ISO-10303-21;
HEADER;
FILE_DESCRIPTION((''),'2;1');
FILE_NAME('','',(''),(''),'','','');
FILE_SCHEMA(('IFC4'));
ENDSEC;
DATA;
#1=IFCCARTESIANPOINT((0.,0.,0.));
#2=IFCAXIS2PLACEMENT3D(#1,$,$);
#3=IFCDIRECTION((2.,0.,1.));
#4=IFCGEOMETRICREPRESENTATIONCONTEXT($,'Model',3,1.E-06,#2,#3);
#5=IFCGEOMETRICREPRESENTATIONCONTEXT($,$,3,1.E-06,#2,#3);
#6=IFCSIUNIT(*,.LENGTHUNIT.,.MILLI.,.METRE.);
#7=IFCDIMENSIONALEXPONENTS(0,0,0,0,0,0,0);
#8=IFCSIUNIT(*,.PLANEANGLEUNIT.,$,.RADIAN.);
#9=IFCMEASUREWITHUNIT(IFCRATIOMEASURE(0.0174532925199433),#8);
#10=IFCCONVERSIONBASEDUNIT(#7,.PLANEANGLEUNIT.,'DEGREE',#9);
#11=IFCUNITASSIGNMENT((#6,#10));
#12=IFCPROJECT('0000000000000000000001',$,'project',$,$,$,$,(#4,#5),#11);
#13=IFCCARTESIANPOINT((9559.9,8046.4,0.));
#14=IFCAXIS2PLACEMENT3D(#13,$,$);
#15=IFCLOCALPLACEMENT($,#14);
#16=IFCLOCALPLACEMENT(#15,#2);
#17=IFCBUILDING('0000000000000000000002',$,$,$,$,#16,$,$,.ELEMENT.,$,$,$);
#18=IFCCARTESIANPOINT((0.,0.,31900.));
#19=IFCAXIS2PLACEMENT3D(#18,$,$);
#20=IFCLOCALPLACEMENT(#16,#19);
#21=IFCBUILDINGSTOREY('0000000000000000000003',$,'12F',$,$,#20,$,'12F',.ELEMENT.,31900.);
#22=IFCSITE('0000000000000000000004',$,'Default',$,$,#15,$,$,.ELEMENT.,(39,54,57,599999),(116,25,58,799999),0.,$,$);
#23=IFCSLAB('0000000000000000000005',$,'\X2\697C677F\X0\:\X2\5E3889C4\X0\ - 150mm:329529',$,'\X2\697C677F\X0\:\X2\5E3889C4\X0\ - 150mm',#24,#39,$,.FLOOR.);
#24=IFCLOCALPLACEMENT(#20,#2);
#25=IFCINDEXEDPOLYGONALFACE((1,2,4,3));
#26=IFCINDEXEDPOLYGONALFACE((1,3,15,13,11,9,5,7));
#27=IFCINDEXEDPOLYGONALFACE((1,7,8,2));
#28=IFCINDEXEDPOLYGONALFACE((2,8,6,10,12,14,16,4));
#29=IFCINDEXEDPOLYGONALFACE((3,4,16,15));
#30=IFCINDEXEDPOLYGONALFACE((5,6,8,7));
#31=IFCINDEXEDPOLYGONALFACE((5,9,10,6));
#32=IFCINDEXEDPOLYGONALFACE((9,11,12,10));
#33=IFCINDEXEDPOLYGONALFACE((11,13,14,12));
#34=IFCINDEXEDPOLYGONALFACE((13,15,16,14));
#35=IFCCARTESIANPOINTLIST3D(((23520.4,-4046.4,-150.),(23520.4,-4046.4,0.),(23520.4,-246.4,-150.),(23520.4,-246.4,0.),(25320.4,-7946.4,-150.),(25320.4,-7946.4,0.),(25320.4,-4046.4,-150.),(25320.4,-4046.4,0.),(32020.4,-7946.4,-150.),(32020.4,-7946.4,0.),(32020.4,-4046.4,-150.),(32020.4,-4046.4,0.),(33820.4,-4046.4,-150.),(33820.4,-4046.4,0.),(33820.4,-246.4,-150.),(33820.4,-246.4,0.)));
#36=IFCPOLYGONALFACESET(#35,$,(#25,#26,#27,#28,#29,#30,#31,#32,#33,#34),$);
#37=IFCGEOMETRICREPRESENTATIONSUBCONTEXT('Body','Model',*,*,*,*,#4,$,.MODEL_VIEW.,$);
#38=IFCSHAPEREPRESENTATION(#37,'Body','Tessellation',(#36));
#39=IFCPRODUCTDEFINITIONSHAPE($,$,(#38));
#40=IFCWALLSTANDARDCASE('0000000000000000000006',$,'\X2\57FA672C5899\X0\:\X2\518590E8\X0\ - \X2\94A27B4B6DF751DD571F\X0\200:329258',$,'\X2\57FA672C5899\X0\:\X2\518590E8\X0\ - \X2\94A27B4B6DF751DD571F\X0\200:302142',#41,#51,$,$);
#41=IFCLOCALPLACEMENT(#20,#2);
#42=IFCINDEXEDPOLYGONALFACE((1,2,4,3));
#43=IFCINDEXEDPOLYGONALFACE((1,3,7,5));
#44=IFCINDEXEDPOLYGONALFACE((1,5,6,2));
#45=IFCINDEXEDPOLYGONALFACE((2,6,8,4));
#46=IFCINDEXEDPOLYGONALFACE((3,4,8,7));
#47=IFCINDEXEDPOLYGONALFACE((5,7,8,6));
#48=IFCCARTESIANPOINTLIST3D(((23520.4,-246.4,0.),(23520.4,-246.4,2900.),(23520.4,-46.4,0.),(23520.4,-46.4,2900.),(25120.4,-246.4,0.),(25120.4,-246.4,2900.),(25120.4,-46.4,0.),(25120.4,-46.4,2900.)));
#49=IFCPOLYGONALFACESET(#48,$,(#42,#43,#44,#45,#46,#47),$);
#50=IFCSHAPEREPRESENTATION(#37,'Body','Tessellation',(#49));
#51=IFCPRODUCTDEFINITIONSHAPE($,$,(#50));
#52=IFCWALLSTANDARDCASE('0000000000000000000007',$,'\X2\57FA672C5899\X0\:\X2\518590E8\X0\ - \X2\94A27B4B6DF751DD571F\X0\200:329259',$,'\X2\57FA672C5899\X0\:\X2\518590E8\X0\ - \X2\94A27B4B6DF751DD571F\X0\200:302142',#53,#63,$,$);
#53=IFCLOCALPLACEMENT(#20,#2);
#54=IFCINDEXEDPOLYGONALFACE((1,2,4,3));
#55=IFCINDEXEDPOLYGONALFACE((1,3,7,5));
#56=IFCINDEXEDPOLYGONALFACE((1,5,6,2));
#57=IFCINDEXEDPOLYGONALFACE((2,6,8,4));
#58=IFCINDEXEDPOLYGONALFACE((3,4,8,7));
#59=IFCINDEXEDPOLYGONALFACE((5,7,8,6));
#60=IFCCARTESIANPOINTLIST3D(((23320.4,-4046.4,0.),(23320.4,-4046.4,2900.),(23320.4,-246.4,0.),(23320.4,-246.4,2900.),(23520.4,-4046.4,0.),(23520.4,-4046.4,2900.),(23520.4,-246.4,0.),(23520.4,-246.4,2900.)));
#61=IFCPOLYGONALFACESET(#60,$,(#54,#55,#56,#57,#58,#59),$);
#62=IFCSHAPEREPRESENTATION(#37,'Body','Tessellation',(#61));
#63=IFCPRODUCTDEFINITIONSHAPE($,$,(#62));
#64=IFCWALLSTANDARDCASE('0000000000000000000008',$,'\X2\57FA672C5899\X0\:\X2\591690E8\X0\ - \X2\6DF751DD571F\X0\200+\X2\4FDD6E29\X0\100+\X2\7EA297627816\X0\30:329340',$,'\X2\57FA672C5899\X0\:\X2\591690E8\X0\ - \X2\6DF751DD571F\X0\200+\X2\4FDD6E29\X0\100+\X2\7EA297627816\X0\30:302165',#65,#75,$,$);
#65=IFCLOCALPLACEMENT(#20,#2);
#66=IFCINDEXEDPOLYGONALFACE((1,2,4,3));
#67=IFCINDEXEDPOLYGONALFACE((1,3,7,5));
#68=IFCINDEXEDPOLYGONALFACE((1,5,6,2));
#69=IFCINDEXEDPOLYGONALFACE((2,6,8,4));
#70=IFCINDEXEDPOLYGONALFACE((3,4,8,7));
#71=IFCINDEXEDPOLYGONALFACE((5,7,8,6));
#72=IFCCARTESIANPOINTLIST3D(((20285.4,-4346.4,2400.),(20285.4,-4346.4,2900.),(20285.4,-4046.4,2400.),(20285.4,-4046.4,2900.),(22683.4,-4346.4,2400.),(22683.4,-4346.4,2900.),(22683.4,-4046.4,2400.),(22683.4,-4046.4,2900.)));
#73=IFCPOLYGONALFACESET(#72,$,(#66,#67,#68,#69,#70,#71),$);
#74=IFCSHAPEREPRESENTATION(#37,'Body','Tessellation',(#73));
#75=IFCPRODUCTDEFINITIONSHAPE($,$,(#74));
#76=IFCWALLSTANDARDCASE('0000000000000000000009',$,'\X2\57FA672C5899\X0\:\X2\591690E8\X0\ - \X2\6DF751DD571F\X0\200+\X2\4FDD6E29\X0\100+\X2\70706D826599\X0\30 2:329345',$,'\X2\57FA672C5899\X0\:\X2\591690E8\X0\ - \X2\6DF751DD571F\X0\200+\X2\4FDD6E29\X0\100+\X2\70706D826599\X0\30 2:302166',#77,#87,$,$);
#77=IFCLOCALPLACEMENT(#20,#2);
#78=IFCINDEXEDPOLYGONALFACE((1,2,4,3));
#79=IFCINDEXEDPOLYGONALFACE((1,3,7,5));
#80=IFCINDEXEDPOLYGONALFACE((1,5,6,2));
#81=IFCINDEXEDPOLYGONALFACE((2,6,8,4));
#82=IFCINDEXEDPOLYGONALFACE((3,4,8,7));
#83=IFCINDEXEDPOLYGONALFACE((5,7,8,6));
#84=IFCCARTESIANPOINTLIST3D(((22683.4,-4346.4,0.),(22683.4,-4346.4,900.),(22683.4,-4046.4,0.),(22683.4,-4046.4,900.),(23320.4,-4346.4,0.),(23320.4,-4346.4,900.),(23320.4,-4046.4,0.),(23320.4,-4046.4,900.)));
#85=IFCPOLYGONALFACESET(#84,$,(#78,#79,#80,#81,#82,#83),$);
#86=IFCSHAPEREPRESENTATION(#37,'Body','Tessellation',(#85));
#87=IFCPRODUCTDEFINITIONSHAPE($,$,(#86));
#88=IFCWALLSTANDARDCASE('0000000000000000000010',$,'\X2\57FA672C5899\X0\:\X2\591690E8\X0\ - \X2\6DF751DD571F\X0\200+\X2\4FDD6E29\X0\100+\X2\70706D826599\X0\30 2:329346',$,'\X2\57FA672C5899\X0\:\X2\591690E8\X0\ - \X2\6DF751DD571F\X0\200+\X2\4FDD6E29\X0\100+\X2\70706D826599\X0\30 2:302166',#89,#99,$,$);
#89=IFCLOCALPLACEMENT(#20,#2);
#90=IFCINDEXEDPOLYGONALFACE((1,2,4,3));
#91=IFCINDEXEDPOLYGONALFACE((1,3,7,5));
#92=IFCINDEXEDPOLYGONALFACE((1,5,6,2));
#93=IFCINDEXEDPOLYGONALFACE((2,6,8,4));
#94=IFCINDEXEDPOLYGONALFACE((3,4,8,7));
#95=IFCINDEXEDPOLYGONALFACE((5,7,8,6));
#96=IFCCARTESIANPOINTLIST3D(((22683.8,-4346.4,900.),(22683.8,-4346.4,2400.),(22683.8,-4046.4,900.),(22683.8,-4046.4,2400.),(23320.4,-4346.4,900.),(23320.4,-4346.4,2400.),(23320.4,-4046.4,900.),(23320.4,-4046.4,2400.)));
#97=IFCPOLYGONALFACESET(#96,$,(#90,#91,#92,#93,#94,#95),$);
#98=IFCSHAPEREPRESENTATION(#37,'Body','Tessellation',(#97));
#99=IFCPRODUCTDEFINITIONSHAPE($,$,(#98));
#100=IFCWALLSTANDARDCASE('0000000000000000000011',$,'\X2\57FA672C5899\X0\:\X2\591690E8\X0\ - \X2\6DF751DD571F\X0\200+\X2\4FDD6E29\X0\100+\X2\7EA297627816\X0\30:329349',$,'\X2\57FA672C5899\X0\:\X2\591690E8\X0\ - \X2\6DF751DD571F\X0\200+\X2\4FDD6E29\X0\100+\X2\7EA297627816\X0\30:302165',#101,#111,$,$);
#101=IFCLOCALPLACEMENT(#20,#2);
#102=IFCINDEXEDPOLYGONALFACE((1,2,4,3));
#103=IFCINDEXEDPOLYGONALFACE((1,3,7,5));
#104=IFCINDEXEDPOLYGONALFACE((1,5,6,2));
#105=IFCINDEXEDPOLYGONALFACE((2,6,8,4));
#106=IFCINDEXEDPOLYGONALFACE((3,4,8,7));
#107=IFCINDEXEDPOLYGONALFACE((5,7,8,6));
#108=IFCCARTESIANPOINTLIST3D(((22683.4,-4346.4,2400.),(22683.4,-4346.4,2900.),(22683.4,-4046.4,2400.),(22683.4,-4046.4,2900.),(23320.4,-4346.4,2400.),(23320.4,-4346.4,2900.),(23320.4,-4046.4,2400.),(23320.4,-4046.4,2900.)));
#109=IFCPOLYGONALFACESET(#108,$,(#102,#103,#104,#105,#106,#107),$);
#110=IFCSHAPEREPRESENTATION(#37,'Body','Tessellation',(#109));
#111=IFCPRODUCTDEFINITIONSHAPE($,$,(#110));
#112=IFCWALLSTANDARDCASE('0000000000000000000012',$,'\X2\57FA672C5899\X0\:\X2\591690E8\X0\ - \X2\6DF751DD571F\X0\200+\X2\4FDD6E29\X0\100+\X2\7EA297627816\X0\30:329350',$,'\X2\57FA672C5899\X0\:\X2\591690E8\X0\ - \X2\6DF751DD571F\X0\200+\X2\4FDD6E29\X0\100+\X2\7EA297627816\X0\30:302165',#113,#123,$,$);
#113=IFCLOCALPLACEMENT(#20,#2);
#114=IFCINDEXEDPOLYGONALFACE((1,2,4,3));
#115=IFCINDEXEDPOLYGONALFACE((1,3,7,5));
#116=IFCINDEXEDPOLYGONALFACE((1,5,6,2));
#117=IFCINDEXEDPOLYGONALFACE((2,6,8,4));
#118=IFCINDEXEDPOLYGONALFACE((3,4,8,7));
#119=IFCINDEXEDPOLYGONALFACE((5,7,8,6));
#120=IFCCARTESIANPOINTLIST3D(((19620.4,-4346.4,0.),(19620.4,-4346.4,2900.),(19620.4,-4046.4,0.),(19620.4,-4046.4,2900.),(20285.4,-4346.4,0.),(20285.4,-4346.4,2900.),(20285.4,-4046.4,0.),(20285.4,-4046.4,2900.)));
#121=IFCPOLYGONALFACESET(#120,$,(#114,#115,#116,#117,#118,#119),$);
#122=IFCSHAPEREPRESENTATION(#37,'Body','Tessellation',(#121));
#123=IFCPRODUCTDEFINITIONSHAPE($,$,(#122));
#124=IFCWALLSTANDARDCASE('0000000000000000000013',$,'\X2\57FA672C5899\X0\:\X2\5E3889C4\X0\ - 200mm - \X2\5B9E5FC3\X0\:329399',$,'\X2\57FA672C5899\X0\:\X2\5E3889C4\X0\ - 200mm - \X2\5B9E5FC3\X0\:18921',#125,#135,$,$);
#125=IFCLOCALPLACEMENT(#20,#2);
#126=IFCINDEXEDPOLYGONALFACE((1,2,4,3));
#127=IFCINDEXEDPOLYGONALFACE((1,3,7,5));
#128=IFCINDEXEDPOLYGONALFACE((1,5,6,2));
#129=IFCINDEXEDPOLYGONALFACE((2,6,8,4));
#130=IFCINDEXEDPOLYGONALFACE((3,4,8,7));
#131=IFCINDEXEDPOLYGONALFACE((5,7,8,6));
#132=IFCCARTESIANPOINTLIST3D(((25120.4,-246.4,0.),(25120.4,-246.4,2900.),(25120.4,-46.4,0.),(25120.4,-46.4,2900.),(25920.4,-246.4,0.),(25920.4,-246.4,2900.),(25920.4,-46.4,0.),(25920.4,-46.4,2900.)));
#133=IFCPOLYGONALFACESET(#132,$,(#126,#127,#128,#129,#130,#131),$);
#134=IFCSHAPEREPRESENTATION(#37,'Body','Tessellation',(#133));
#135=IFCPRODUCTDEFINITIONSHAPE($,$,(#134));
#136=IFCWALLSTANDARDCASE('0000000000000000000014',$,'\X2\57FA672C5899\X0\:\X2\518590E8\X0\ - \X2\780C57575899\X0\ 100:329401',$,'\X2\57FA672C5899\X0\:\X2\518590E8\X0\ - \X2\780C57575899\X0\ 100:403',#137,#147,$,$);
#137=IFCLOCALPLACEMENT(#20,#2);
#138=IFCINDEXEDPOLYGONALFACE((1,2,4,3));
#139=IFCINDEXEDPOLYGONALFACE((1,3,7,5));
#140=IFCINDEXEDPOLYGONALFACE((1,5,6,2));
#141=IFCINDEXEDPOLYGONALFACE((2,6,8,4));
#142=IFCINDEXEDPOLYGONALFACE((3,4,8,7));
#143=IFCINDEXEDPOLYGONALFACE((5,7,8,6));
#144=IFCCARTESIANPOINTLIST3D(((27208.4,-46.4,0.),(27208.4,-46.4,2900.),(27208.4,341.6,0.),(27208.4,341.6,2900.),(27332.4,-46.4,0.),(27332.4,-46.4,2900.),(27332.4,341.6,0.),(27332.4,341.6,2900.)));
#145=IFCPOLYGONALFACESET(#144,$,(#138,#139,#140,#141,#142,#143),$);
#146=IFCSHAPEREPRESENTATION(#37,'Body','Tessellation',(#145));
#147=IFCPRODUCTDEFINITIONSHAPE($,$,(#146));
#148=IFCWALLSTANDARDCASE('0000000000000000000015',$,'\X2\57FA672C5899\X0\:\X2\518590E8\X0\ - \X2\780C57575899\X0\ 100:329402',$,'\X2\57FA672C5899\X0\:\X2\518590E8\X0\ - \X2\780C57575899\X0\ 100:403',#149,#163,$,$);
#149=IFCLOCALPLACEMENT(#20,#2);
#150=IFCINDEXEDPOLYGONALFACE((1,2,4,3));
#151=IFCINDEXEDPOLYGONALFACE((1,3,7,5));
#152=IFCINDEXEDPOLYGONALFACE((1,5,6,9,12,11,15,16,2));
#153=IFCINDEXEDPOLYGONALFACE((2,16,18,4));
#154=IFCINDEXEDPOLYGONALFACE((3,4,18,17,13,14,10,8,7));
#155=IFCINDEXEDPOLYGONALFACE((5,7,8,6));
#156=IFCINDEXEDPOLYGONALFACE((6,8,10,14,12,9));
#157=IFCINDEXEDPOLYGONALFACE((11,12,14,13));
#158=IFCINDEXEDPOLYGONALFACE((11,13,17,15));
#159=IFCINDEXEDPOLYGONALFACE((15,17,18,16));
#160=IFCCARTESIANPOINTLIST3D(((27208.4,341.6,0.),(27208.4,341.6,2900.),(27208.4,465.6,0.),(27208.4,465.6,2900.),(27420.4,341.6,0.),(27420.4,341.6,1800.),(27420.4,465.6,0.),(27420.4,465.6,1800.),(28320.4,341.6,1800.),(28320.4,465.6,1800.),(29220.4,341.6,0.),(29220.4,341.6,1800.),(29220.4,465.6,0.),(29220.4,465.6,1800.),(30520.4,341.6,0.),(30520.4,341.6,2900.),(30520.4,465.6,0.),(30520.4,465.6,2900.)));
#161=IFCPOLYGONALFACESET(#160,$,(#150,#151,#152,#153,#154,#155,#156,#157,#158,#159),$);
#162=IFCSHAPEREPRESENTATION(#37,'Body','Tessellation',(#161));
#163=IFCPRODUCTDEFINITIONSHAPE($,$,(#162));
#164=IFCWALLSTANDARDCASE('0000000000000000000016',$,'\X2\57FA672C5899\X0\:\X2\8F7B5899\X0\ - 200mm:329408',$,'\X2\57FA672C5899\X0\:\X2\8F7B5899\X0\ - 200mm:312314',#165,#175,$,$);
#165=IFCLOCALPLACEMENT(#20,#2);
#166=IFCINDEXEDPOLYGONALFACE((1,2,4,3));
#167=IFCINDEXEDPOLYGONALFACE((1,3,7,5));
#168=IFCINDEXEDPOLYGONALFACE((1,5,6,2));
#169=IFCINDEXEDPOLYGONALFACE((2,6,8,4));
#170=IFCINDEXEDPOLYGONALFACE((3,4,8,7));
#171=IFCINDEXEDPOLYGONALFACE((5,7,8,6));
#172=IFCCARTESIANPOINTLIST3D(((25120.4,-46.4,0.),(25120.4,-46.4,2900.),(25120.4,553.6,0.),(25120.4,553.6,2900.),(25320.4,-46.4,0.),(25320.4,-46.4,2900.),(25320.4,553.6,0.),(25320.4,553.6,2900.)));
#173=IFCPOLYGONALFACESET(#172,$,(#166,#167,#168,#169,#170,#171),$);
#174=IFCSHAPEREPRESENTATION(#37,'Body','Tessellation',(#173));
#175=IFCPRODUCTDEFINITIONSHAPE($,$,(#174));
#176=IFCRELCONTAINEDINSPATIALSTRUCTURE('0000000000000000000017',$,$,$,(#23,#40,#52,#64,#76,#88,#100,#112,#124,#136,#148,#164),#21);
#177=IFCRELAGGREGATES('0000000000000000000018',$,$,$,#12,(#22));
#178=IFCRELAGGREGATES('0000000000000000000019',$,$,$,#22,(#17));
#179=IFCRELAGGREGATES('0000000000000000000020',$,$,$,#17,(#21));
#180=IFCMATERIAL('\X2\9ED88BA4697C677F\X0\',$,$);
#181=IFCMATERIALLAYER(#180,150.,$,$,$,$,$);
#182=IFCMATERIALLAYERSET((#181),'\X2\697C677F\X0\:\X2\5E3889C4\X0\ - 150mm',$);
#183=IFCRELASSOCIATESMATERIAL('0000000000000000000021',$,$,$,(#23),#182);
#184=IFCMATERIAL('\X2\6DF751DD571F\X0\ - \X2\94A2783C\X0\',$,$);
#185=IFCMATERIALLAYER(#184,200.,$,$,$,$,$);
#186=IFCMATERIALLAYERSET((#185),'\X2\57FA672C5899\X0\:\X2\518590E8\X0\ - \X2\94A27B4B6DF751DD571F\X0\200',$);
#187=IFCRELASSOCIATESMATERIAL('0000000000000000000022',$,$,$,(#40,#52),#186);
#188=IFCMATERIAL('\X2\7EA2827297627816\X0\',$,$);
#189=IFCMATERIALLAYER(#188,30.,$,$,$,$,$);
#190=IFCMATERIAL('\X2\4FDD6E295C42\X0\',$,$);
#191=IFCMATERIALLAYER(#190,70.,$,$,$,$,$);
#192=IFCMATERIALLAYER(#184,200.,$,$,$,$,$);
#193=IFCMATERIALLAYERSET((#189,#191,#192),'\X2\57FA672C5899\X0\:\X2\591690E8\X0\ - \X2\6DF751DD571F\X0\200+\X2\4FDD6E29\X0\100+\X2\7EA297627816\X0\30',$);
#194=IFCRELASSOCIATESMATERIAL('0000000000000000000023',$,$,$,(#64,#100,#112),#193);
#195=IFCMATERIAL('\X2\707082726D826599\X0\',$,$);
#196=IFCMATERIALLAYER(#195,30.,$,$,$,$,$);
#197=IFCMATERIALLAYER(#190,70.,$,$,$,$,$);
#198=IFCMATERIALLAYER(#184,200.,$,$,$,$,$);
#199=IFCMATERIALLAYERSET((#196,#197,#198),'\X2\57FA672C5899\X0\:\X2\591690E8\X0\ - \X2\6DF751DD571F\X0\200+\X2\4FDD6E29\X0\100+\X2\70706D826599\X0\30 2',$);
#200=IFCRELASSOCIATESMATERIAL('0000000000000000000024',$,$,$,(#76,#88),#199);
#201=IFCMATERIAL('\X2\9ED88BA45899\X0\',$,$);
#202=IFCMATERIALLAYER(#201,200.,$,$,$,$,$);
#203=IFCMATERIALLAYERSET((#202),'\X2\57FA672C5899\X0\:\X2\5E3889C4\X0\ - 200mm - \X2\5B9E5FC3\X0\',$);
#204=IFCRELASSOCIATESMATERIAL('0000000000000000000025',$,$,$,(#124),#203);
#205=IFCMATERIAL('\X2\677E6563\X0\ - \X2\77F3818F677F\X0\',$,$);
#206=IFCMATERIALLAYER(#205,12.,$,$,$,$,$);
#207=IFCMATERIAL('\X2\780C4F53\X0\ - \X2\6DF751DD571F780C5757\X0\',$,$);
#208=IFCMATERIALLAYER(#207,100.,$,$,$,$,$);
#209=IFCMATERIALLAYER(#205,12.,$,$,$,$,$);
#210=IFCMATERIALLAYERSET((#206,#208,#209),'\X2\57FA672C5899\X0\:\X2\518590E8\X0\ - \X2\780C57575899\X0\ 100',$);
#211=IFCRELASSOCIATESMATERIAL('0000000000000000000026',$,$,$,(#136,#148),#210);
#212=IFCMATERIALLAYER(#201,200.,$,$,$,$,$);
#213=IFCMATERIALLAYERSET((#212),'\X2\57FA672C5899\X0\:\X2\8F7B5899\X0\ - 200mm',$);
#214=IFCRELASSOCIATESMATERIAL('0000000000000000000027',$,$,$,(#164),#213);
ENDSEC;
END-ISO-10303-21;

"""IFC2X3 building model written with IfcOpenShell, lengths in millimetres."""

from ifc_helpers import new_model, entity, si_unit, converted_unit, direction, frame, frame_2d, origin, place, context, subcontext, project, spatial, polyline, rectangle, outline, extrude, material, layer, layer_set, layer_usage, element, save


model = new_model("IFC2X3")

# Units and contexts
model_context = context("Model", 3, precision=1e-06, world=origin(), true_north=direction((2.0, 0.0, 1.0)))
context_of_model = context(None, 3, precision=1e-06, world=origin(), true_north=direction((2.0, 0.0, 1.0)))
body_context = subcontext(model_context, "Body", "Model", "MODEL_VIEW")
ifc_project = project(units=[si_unit("LENGTHUNIT", "METRE", prefix="MILLI"), converted_unit("PLANEANGLEUNIT", "DEGREE", entity("IfcRatioMeasure", 0.0174532925199433), si_unit("PLANEANGLEUNIT", "RADIAN"), dimensions=[0, 0, 0, 0, 0, 0, 0])], contexts=[model_context, context_of_model])

# Site, building, storey
site_placement = place(None, frame((9559.9, 8046.4, 0.0)))
site = spatial("IfcSite", under=ifc_project, at=site_placement, Name="Default", CompositionType="ELEMENT", RefLatitude=(39, 54, 57, 599999), RefLongitude=(116, 25, 58, 799999), RefElevation=0.0)
building_placement = place(site_placement, origin())
building = spatial("IfcBuilding", under=site, at=building_placement, CompositionType="ELEMENT")
storey_placement = place(building_placement, frame((0.0, 0.0, 31900.0)))
storey = spatial("IfcBuildingStorey", under=building, at=storey_placement, Name="12F", LongName="12F", CompositionType="ELEMENT", Elevation=31900.0)

# Slab
ifc_material_1 = material(Name="默认楼板")
ifc_layer_1 = layer(ifc_material_1, 150.0)
ifc_layer_set_1 = layer_set([ifc_layer_1], Name="楼板:常规 - 150mm")
ifc_layer_usage_1 = layer_usage(ifc_layer_set_1, "AXIS3", "POSITIVE", 0.0)
slab_placement = place(storey_placement, frame((23520.4, -7946.4, -150.0)))
element("IfcSlab", 1, at=slab_placement, inside=storey, material=ifc_layer_usage_1, Name="楼板:常规 - 150mm:329529", ObjectType="楼板:常规 - 150mm", PredefinedType="FLOOR", context=body_context, shape_type="SweptSolid", body=[
    extrude(outline(polyline([(-5150.0, 50.0), (-3350.0, 50.0), (-3350.0, -3850.0), (3350.0, -3850.0), (3350.0, 50.0), (5150.0, 50.0), (5150.0, 3850.0), (-5150.0, 3850.0), (-5150.0, 50.0)])), frame((5150.0, 3850.0, 150.0), z_axis=(0.0, 0.0, -1.0), x_axis=(-1.0, 0.0, 0.0)), (0.0, 0.0, 1.0), 150.0),
])

# Walls
ifc_material_2 = material(Name="混凝土 - 钢砼")
ifc_layer_2 = layer(ifc_material_2, 200.0)
ifc_layer_set_2 = layer_set([ifc_layer_2], Name="基本墙:内部 - 钢筋混凝土200")
ifc_layer_usage_2 = layer_usage(ifc_layer_set_2, "AXIS2", "NEGATIVE", 100.0)
wall_1_placement = place(storey_placement, frame((25120.4, -146.4, 0.0), z_axis=(0.0, 0.0, 1.0), x_axis=(-1.0, 0.0, 0.0)))
element("IfcWallStandardCase", 2, at=wall_1_placement, inside=storey, material=ifc_layer_usage_2, Name="基本墙:内部 - 钢筋混凝土200:329258", ObjectType="基本墙:内部 - 钢筋混凝土200:302142", context=body_context, shape_type="SweptSolid", body=[
    extrude(rectangle(XDim=1600.0, YDim=200.0, at=frame_2d((800.0, 0.0), x_axis=(-1.0, 0.0))), origin(), (0.0, 0.0, 1.0), 2900.0),
])
ifc_layer_usage_3 = layer_usage(ifc_layer_set_2, "AXIS2", "NEGATIVE", 100.0)
wall_2_placement = place(storey_placement, frame((23420.4, -4046.4, 0.0), z_axis=(0.0, 0.0, 1.0), x_axis=(0.0, 1.0, 0.0)))
element("IfcWallStandardCase", 3, at=wall_2_placement, inside=storey, material=ifc_layer_usage_3, Name="基本墙:内部 - 钢筋混凝土200:329259", ObjectType="基本墙:内部 - 钢筋混凝土200:302142", context=body_context, shape_type="SweptSolid", body=[
    extrude(rectangle(XDim=3800.0, YDim=200.0, at=frame_2d((1900.0, 0.0), x_axis=(-1.0, 0.0))), origin(), (0.0, 0.0, 1.0), 2900.0),
])
ifc_material_3 = material(Name="红色面砖")
ifc_layer_3 = layer(ifc_material_3, 30.0)
ifc_material_4 = material(Name="保温层")
ifc_layer_4 = layer(ifc_material_4, 70.0)
ifc_layer_5 = layer(ifc_material_2, 200.0)
ifc_layer_set_3 = layer_set([ifc_layer_3, ifc_layer_4, ifc_layer_5], Name="基本墙:外部 - 混凝土200+保温100+红面砖30")
ifc_layer_usage_4 = layer_usage(ifc_layer_set_3, "AXIS2", "POSITIVE", -150.0)
wall_3_placement = place(storey_placement, frame((20285.4, -4196.4, 2400.0)))
element("IfcWallStandardCase", 4, at=wall_3_placement, inside=storey, material=ifc_layer_usage_4, Name="基本墙:外部 - 混凝土200+保温100+红面砖30:329340", ObjectType="基本墙:外部 - 混凝土200+保温100+红面砖30:302165", context=body_context, shape_type="SweptSolid", body=[
    extrude(rectangle(XDim=2398.1, YDim=300.0, at=frame_2d((1199.0, 0.0), x_axis=(-1.0, 0.0))), origin(), (0.0, 0.0, 1.0), 500.0),
])

# Walls
ifc_material_5 = material(Name="灰色涂料")
ifc_layer_6 = layer(ifc_material_5, 30.0)
ifc_layer_7 = layer(ifc_material_4, 70.0)
ifc_layer_8 = layer(ifc_material_2, 200.0)
ifc_layer_set_4 = layer_set([ifc_layer_6, ifc_layer_7, ifc_layer_8], Name="基本墙:外部 - 混凝土200+保温100+灰涂料30 2")
ifc_layer_usage_5 = layer_usage(ifc_layer_set_4, "AXIS2", "POSITIVE", -150.0)
wall_4_placement = place(storey_placement, frame((22683.4, -4196.4, 0.0)))
element("IfcWallStandardCase", 5, at=wall_4_placement, inside=storey, material=ifc_layer_usage_5, Name="基本墙:外部 - 混凝土200+保温100+灰涂料30 2:329345", ObjectType="基本墙:外部 - 混凝土200+保温100+灰涂料30 2:302166", context=body_context, shape_type="SweptSolid", body=[
    extrude(rectangle(XDim=636.9, YDim=300.0, at=frame_2d((318.5, 0.0), x_axis=(-1.0, 0.0))), origin(), (0.0, 0.0, 1.0), 900.0),
])
ifc_layer_usage_6 = layer_usage(ifc_layer_set_4, "AXIS2", "POSITIVE", -150.0)
wall_5_placement = place(storey_placement, frame((22683.8, -4196.4, 900.0)))
element("IfcWallStandardCase", 6, at=wall_5_placement, inside=storey, material=ifc_layer_usage_6, Name="基本墙:外部 - 混凝土200+保温100+灰涂料30 2:329346", ObjectType="基本墙:外部 - 混凝土200+保温100+灰涂料30 2:302166", context=body_context, shape_type="SweptSolid", body=[
    extrude(rectangle(XDim=636.6, YDim=300.0, at=frame_2d((318.3, 0.0), x_axis=(-1.0, 0.0))), origin(), (0.0, 0.0, 1.0), 1500.0),
])
ifc_layer_usage_7 = layer_usage(ifc_layer_set_3, "AXIS2", "POSITIVE", -150.0)
wall_6_placement = place(storey_placement, frame((22683.4, -4196.4, 2400.0)))
element("IfcWallStandardCase", 7, at=wall_6_placement, inside=storey, material=ifc_layer_usage_7, Name="基本墙:外部 - 混凝土200+保温100+红面砖30:329349", ObjectType="基本墙:外部 - 混凝土200+保温100+红面砖30:302165", context=body_context, shape_type="SweptSolid", body=[
    extrude(rectangle(XDim=636.9, YDim=300.0, at=frame_2d((318.5, 0.0), x_axis=(-1.0, 0.0))), origin(), (0.0, 0.0, 1.0), 500.0),
])
ifc_layer_usage_8 = layer_usage(ifc_layer_set_3, "AXIS2", "POSITIVE", -150.0)
wall_7_placement = place(storey_placement, frame((19620.4, -4196.4, 0.0)))
element("IfcWallStandardCase", 8, at=wall_7_placement, inside=storey, material=ifc_layer_usage_8, Name="基本墙:外部 - 混凝土200+保温100+红面砖30:329350", ObjectType="基本墙:外部 - 混凝土200+保温100+红面砖30:302165", context=body_context, shape_type="SweptSolid", body=[
    extrude(rectangle(XDim=665.0, YDim=300.0, at=frame_2d((332.5, 0.0), x_axis=(-1.0, 0.0))), origin(), (0.0, 0.0, 1.0), 2900.0),
])
ifc_material_6 = material(Name="默认墙")
ifc_layer_9 = layer(ifc_material_6, 200.0)
ifc_layer_set_5 = layer_set([ifc_layer_9], Name="基本墙:常规 - 200mm - 实心")
ifc_layer_usage_9 = layer_usage(ifc_layer_set_5, "AXIS2", "POSITIVE", -100.0)
wall_8_placement = place(storey_placement, frame((25120.4, -146.4, 0.0)))
element("IfcWallStandardCase", 9, at=wall_8_placement, inside=storey, material=ifc_layer_usage_9, Name="基本墙:常规 - 200mm - 实心:329399", ObjectType="基本墙:常规 - 200mm - 实心:18921", context=body_context, shape_type="SweptSolid", body=[
    extrude(rectangle(XDim=800.0, YDim=200.0, at=frame_2d((400.0, 0.0), x_axis=(-1.0, 0.0))), origin(), (0.0, 0.0, 1.0), 2900.0),
])
ifc_material_7 = material(Name="松散 - 石膏板")
ifc_layer_10 = layer(ifc_material_7, 12.0)
ifc_material_8 = material(Name="砌体 - 混凝土砌块")
ifc_layer_11 = layer(ifc_material_8, 100.0)
ifc_layer_12 = layer(ifc_material_7, 12.0)
ifc_layer_set_6 = layer_set([ifc_layer_10, ifc_layer_11, ifc_layer_12], Name="基本墙:内部 - 砌块墙 100")
ifc_layer_usage_10 = layer_usage(ifc_layer_set_6, "AXIS2", "POSITIVE", -62.0)
wall_9_placement = place(storey_placement, frame((27270.4, -46.4, 0.0), z_axis=(0.0, 0.0, 1.0), x_axis=(0.0, 1.0, 0.0)))
element("IfcWallStandardCase", 10, at=wall_9_placement, inside=storey, material=ifc_layer_usage_10, Name="基本墙:内部 - 砌块墙 100:329401", ObjectType="基本墙:内部 - 砌块墙 100:403", context=body_context, shape_type="SweptSolid", body=[
    extrude(rectangle(XDim=388.0, YDim=124.0, at=frame_2d((194.0, 0.0), x_axis=(-1.0, 0.0))), origin(), (0.0, 0.0, 1.0), 2900.0),
])

# Wall, openings
ifc_layer_usage_11 = layer_usage(ifc_layer_set_6, "AXIS2", "POSITIVE", -62.0)
wall_10_placement = place(storey_placement, frame((27208.4, 403.6, 0.0)))
wall_10 = element("IfcWallStandardCase", 11, at=wall_10_placement, inside=storey, material=ifc_layer_usage_11, Name="基本墙:内部 - 砌块墙 100:329402", ObjectType="基本墙:内部 - 砌块墙 100:403", context=body_context, shape_type="SweptSolid", body=[
    extrude(rectangle(XDim=3312.0, YDim=124.0, at=frame_2d((1656.0, 0.0), x_axis=(-1.0, 0.0))), origin(), (0.0, 0.0, 1.0), 2900.0),
])
opening_1_placement = place(wall_10_placement, frame((1112.0, -62.0, 0.0)))
element("IfcOpeningElement", 12, at=opening_1_placement, cuts=wall_10, ObjectType="Opening", context=body_context, shape_type="SweptSolid", body=[
    extrude(rectangle(XDim=1800.0, YDim=900.0, at=frame_2d((900.0, 450.0), x_axis=(1.0, 0.0))), frame((0.0, 0.0, 0.0), z_axis=(0.0, 1.0, 0.0), x_axis=(0.0, 0.0, 1.0)), (0.0, 0.0, 1.0), 124.0),
])
opening_2_placement = place(wall_10_placement, frame((212.0, -62.0, 0.0)))
element("IfcOpeningElement", 13, at=opening_2_placement, cuts=wall_10, ObjectType="Opening", context=body_context, shape_type="SweptSolid", body=[
    extrude(rectangle(XDim=1800.0, YDim=900.0, at=frame_2d((900.0, 450.0), x_axis=(1.0, 0.0))), frame((0.0, 0.0, 0.0), z_axis=(0.0, 1.0, 0.0), x_axis=(0.0, 0.0, 1.0)), (0.0, 0.0, 1.0), 124.0),
])

# Wall
ifc_layer_13 = layer(ifc_material_6, 200.0)
ifc_layer_set_7 = layer_set([ifc_layer_13], Name="基本墙:轻墙 - 200mm")
ifc_layer_usage_12 = layer_usage(ifc_layer_set_7, "AXIS2", "POSITIVE", -100.0)
wall_11_placement = place(storey_placement, frame((25220.4, -46.4, 0.0), z_axis=(0.0, 0.0, 1.0), x_axis=(0.0, 1.0, 0.0)))
element("IfcWallStandardCase", 14, at=wall_11_placement, inside=storey, material=ifc_layer_usage_12, Name="基本墙:轻墙 - 200mm:329408", ObjectType="基本墙:轻墙 - 200mm:312314", context=body_context, shape_type="SweptSolid", body=[
    extrude(rectangle(XDim=600.0, YDim=200.0, at=frame_2d((300.0, 0.0), x_axis=(-1.0, 0.0))), origin(), (0.0, 0.0, 1.0), 2900.0),
])

save(model, "model.ifc")
